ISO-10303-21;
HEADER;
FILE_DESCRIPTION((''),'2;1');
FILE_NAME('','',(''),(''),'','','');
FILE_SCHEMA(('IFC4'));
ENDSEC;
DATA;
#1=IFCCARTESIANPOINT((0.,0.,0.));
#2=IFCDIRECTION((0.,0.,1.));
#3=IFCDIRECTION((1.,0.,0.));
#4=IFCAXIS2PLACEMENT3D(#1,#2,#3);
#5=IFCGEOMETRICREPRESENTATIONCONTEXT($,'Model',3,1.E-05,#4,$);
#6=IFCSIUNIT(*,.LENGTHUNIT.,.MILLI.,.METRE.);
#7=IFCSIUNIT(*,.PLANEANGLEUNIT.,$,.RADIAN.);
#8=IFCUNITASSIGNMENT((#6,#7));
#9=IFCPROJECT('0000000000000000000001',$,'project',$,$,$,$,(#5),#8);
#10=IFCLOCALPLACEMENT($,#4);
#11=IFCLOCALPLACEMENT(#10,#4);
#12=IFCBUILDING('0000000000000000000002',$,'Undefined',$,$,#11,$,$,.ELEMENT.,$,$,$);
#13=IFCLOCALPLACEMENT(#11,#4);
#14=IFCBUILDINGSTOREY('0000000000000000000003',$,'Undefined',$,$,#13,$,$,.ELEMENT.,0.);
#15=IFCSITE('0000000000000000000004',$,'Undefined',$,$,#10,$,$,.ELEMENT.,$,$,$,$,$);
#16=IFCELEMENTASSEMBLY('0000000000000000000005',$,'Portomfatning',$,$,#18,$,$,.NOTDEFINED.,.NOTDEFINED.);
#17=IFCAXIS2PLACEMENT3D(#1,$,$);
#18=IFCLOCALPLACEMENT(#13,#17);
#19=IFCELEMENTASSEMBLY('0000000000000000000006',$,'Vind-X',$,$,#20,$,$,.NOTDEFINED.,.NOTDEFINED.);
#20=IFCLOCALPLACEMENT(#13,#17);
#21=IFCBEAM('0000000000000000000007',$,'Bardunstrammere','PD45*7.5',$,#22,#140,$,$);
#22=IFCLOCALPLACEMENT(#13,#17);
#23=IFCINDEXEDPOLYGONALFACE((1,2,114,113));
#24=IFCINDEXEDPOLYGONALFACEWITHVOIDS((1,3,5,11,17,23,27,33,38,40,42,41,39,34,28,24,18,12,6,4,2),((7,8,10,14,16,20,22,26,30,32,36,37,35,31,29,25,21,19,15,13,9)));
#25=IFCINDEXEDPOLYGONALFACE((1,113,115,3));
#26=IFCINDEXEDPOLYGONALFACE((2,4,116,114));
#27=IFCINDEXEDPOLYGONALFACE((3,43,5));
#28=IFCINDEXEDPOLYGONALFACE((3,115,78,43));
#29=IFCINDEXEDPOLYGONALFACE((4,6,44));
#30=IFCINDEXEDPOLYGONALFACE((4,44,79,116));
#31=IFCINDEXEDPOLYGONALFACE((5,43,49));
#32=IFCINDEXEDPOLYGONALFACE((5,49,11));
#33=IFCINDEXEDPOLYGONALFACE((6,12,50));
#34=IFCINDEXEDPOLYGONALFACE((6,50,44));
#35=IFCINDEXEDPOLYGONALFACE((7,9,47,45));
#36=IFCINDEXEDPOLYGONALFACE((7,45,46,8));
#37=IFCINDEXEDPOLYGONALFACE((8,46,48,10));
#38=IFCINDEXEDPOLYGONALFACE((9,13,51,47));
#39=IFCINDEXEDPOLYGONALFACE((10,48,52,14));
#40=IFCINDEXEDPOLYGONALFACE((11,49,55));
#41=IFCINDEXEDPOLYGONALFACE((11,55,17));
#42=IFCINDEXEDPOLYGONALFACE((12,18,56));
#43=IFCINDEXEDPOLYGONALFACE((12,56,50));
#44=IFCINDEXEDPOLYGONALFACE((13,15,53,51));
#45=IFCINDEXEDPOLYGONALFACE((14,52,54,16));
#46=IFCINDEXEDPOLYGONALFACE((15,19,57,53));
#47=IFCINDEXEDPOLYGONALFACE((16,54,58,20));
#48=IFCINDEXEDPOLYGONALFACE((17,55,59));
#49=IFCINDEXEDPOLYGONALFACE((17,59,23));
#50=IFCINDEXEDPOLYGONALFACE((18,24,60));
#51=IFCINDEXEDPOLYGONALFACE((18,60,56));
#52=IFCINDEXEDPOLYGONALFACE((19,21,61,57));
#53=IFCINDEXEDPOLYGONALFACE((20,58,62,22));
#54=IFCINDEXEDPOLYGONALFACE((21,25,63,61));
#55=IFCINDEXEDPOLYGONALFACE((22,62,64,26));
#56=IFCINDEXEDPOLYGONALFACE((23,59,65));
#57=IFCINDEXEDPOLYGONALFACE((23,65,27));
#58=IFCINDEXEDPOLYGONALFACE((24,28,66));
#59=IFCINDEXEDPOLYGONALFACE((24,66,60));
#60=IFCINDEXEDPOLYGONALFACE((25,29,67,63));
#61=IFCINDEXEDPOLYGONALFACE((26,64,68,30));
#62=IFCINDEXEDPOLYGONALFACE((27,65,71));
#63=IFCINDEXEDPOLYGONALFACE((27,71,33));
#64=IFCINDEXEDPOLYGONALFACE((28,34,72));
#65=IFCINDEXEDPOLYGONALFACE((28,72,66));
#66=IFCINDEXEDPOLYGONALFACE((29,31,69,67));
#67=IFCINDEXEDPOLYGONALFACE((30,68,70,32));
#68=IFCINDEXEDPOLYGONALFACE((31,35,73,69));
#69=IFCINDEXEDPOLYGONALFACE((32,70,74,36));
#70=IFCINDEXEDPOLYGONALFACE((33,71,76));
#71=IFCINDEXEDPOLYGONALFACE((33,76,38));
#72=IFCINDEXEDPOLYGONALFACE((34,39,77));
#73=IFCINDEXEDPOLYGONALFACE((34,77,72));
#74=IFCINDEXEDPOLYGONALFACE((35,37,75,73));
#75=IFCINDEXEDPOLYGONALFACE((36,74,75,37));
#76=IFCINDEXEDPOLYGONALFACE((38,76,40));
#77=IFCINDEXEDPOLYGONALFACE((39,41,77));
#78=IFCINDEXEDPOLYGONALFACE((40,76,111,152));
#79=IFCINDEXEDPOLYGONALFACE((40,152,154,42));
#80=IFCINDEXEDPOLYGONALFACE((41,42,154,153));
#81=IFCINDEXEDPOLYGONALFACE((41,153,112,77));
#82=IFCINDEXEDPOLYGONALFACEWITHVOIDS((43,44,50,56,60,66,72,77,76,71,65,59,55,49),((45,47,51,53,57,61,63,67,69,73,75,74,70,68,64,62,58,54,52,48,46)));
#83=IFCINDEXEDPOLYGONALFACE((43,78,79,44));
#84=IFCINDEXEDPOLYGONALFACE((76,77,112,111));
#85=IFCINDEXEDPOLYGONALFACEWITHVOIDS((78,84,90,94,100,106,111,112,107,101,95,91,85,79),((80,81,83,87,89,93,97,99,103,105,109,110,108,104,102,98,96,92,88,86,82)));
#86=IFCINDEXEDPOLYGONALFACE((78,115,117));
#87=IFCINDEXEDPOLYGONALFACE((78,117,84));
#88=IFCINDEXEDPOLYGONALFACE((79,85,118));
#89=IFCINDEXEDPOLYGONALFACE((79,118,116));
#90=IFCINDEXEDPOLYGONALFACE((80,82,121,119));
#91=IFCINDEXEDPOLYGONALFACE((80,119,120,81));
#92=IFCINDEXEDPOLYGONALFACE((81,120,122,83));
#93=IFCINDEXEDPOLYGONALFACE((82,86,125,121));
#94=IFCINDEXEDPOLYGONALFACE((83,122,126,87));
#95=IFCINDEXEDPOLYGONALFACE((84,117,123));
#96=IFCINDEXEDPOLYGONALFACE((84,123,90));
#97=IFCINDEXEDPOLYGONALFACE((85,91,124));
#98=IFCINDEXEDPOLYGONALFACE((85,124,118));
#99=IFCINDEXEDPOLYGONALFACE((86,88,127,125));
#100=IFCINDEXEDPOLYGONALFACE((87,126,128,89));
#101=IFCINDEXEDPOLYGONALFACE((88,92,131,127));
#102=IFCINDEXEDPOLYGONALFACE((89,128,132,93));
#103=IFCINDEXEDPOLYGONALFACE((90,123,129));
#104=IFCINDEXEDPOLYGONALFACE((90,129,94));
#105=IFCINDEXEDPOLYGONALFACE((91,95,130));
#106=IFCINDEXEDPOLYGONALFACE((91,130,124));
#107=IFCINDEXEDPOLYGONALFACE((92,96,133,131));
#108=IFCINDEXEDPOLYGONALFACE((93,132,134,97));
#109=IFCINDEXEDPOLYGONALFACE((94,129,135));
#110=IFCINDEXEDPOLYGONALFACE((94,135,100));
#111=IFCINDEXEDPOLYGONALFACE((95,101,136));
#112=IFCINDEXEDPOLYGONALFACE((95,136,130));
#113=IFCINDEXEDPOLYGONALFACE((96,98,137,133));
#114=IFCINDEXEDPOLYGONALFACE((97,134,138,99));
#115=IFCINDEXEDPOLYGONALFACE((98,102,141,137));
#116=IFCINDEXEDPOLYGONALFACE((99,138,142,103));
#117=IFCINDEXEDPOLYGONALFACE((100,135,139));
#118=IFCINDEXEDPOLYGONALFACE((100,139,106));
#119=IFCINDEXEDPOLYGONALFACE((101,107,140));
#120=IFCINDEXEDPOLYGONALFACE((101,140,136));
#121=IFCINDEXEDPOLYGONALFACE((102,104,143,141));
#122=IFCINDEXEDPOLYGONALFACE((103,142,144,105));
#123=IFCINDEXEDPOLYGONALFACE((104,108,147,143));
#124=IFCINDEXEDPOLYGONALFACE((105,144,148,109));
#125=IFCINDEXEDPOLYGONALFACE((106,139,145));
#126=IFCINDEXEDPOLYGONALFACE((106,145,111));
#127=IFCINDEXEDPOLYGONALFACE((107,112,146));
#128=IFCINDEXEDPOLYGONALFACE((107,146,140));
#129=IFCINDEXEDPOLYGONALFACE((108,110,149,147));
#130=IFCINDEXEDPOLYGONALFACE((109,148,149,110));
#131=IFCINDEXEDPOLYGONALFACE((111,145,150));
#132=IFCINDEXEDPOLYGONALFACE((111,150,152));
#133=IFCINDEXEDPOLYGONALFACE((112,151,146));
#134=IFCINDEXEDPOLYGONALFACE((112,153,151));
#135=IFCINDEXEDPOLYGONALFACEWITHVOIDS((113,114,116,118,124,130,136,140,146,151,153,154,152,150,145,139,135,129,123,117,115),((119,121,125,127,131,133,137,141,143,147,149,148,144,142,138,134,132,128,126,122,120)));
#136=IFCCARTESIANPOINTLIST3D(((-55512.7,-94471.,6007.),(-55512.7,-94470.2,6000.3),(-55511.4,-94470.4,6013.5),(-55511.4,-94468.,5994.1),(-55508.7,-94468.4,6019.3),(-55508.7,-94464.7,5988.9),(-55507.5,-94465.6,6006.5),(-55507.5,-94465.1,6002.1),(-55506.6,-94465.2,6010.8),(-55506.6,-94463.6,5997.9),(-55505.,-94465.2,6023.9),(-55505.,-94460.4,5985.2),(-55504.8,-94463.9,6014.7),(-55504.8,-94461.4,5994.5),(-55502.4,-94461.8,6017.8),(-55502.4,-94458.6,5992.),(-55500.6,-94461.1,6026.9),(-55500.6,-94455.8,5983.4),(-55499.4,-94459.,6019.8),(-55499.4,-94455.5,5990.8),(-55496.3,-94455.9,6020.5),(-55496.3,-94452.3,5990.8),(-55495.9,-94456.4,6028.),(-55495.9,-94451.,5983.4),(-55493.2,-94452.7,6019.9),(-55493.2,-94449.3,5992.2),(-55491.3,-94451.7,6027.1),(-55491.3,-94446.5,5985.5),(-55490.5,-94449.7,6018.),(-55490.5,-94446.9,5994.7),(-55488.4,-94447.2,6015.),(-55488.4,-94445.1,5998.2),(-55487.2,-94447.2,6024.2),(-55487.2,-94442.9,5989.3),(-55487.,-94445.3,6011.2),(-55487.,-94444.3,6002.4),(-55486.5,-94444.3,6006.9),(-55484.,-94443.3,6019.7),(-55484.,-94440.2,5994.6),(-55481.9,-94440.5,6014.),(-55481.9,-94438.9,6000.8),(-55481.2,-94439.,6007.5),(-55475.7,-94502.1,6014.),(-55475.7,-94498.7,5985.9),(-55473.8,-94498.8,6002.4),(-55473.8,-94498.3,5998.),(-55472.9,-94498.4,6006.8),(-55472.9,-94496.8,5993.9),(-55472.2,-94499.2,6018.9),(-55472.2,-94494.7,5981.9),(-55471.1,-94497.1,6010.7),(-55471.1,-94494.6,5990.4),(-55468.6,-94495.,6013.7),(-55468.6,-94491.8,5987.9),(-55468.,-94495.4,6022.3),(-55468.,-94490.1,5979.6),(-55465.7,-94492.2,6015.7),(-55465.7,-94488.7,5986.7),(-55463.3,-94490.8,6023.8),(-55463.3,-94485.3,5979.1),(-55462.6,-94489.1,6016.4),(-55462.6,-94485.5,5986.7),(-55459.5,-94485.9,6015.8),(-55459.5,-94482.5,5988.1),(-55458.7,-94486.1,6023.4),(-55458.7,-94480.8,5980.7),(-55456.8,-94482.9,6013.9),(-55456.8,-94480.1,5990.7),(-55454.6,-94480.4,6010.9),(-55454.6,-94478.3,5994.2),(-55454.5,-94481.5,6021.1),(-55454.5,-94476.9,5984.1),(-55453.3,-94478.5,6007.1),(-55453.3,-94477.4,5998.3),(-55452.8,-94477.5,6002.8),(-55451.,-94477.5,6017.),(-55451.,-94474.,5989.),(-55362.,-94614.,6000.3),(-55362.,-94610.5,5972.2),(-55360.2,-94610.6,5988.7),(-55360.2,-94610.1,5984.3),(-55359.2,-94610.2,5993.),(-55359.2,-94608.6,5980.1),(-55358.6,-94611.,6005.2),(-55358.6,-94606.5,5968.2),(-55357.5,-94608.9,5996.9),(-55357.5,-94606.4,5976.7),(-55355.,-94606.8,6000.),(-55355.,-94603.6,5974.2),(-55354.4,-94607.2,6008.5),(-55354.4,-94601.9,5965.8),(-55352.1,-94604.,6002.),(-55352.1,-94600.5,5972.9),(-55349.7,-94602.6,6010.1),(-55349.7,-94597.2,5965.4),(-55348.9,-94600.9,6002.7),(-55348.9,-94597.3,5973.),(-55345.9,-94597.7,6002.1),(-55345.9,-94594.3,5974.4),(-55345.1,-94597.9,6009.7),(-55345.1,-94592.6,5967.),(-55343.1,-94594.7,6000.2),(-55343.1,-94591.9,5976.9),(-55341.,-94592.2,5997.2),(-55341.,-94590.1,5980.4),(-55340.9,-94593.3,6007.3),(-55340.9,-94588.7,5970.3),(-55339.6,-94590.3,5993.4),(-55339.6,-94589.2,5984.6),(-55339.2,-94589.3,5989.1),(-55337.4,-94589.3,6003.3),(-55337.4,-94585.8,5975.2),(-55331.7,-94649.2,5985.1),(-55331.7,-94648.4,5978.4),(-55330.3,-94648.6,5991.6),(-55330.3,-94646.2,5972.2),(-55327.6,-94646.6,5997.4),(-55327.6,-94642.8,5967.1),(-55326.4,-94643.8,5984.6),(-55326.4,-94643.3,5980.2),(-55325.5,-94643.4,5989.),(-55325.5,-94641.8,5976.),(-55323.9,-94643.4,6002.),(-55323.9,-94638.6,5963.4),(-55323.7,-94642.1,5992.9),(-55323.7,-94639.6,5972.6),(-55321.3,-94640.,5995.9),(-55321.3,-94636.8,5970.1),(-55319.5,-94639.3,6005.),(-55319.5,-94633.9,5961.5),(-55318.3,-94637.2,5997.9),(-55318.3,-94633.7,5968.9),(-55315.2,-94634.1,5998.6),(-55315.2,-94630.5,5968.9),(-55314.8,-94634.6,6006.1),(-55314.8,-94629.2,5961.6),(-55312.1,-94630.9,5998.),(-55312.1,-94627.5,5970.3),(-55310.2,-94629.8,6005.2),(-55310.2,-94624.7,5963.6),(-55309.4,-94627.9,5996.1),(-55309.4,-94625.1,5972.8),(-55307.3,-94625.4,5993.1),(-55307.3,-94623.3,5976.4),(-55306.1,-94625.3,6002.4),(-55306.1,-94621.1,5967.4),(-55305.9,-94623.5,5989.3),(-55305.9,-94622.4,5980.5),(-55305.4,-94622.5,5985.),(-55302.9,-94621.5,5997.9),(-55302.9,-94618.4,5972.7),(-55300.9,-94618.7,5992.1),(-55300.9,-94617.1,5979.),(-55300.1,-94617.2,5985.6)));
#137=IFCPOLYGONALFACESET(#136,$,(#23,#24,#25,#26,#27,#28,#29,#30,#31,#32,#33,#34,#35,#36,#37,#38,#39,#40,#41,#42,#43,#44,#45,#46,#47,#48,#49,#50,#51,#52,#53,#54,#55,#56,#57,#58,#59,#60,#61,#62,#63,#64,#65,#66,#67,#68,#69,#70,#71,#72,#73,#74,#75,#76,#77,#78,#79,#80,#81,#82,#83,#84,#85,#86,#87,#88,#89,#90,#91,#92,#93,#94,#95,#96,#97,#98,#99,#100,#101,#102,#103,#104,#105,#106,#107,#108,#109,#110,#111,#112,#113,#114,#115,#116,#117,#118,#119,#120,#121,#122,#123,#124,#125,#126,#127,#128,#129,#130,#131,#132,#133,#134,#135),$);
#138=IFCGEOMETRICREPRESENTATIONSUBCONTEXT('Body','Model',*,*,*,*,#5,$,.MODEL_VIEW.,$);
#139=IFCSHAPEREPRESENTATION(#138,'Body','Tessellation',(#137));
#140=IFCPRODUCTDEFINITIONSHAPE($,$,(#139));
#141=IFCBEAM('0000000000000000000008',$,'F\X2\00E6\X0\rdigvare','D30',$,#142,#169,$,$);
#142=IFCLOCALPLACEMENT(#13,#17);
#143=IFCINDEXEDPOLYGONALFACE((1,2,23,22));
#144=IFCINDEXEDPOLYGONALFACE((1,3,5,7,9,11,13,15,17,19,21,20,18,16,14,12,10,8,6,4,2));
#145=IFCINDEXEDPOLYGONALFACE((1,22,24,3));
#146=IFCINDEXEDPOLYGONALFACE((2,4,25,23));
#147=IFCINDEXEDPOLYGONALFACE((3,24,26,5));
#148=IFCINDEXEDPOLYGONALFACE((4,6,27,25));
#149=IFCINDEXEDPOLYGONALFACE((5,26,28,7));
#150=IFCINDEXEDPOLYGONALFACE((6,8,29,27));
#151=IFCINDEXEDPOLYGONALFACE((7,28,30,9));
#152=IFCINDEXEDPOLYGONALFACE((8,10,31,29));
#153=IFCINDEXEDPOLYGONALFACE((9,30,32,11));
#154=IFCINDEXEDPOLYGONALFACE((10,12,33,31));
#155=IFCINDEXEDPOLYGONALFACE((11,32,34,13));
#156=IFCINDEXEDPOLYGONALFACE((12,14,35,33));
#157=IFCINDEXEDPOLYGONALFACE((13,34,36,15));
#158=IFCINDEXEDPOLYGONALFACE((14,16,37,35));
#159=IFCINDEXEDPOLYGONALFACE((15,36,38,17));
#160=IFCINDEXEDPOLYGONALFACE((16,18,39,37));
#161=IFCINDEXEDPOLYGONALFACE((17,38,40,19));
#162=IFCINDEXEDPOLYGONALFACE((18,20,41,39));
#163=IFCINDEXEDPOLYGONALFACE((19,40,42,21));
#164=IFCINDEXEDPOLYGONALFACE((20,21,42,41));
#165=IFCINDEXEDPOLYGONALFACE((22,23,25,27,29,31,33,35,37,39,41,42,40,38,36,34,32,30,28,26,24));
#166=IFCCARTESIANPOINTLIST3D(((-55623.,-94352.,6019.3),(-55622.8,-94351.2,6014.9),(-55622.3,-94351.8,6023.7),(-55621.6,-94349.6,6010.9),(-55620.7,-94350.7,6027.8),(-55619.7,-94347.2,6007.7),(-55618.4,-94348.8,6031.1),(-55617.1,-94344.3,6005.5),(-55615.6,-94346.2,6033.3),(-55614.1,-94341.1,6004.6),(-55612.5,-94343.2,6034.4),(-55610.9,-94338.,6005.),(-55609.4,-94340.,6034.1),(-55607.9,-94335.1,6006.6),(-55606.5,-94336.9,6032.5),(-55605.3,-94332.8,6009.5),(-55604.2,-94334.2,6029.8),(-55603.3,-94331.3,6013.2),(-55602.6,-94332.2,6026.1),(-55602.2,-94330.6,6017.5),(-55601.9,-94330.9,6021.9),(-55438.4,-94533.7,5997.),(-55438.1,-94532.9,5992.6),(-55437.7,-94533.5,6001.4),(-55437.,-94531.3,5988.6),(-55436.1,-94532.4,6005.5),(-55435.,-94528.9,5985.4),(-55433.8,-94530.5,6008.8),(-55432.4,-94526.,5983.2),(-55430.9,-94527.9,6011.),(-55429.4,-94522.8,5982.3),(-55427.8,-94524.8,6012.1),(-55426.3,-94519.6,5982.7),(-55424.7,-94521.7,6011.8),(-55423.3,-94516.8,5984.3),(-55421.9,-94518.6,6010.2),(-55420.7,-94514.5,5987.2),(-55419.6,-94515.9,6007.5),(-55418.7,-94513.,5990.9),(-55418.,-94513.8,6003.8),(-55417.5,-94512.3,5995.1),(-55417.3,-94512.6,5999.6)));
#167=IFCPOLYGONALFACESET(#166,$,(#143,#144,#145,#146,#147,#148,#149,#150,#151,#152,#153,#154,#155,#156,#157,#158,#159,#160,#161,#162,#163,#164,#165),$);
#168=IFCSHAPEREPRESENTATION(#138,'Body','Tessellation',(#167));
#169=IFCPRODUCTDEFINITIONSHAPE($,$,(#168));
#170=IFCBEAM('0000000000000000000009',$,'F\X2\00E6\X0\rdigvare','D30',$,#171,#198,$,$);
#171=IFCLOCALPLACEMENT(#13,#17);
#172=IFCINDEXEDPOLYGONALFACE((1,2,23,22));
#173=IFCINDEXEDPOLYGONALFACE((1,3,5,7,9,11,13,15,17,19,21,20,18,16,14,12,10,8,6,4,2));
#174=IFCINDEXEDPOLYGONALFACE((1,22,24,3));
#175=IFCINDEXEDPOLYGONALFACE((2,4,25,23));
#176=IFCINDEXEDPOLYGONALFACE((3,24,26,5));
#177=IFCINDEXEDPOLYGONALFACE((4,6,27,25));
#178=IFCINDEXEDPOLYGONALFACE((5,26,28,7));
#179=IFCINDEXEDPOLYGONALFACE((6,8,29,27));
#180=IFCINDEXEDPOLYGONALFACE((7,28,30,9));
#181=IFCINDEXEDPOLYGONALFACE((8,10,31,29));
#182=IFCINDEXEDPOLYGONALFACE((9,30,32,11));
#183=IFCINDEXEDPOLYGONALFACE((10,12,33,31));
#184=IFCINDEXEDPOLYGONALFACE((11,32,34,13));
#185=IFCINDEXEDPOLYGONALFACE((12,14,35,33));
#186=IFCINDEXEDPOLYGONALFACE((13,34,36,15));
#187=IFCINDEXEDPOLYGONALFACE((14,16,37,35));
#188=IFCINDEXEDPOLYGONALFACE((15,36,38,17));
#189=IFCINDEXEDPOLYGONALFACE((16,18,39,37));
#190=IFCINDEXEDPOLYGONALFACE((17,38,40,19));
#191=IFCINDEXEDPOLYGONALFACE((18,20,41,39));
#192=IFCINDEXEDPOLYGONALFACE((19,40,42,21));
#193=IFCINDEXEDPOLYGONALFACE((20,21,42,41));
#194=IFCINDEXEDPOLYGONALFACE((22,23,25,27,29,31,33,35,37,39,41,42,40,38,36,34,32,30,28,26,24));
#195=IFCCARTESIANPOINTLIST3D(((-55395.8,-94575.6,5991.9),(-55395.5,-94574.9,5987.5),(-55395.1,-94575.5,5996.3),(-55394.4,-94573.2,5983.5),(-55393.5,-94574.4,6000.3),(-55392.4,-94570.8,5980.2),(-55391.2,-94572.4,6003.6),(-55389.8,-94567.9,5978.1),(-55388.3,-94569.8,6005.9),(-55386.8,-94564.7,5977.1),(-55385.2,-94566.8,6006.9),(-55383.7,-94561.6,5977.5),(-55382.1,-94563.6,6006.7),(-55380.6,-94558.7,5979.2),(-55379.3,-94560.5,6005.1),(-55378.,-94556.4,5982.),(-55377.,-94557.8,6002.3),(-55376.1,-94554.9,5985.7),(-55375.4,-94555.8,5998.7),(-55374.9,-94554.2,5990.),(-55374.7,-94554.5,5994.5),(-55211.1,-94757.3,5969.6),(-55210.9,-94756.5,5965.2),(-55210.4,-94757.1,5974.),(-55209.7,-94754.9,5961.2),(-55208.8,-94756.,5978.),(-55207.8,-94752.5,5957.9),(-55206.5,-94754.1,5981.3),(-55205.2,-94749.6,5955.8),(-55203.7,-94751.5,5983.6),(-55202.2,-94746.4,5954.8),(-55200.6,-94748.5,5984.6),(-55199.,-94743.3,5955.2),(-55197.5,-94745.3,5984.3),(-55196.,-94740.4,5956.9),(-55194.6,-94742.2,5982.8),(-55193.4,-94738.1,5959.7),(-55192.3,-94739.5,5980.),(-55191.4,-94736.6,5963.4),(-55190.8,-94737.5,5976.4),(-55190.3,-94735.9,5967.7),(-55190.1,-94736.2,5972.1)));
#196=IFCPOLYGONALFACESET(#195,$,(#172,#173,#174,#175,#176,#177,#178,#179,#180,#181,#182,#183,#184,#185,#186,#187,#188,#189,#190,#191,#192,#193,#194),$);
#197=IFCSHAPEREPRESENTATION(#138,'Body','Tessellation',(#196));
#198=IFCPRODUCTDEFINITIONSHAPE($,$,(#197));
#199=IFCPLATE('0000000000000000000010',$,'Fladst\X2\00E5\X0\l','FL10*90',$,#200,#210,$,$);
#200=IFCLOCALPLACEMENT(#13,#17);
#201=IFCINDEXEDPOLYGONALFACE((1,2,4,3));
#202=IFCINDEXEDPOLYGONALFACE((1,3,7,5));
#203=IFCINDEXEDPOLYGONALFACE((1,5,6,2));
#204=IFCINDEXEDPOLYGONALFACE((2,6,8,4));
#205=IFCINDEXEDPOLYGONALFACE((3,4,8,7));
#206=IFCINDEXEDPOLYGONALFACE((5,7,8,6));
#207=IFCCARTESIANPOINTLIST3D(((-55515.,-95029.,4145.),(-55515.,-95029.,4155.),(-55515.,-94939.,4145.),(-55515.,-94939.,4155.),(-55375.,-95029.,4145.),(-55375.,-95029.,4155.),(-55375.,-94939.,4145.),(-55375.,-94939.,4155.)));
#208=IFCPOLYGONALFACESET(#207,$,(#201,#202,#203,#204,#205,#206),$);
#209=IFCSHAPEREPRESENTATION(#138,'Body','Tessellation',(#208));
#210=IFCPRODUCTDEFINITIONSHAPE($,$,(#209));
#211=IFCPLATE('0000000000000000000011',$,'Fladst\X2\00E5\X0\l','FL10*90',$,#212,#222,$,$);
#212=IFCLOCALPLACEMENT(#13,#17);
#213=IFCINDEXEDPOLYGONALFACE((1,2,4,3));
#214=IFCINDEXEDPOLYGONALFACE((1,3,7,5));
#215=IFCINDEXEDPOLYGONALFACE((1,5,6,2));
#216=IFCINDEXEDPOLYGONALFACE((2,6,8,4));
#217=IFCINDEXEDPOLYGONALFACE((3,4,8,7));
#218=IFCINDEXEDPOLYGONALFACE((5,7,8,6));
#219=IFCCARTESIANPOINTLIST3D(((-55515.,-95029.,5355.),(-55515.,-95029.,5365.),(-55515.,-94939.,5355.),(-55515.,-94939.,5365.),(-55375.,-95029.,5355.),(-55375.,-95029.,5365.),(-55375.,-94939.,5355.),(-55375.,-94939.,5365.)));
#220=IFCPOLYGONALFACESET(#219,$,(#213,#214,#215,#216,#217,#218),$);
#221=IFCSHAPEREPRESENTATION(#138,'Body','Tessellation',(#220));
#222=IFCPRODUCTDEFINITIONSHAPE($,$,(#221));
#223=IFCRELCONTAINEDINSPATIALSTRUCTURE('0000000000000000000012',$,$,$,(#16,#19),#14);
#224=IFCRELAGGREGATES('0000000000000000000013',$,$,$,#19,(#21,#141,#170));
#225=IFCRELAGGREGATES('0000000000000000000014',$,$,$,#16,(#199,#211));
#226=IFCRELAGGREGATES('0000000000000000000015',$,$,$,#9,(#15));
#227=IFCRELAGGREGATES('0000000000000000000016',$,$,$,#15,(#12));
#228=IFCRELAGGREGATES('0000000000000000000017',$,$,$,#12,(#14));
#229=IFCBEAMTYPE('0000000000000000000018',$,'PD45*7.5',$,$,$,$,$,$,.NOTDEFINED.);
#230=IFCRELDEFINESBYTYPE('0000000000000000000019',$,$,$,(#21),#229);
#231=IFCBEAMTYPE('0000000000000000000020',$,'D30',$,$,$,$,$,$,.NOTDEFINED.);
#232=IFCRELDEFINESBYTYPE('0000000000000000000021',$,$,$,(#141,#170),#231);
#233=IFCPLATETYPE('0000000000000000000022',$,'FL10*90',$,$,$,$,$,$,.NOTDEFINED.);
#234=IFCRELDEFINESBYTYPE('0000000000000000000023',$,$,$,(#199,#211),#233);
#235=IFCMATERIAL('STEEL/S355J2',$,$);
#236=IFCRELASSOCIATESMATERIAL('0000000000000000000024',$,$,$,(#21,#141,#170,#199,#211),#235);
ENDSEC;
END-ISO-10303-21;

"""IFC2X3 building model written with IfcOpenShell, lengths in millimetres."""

from ifc_helpers import new_model, si_unit, frame, origin_with_axes, origin_2d_with_axis, place, context, subcontext, project, spatial, polyline, rectangle, circle, hollow_circle, outline, extrude, boolean, material, type_object, element, aggregate, save


model = new_model("IFC2X3")

# Units and contexts
model_context = context("Model", 3, precision=1e-05, world=origin_with_axes())
body_context = subcontext(model_context, "Body", "Model", "MODEL_VIEW")
ifc_project = project(units=[si_unit("LENGTHUNIT", "METRE", prefix="MILLI"), si_unit("PLANEANGLEUNIT", "RADIAN")], contexts=[model_context])

# Site, building, storey
site_placement = place(None, origin_with_axes())
site = spatial("IfcSite", under=ifc_project, at=site_placement, Name="Undefined", CompositionType="ELEMENT")
building_placement = place(site_placement, origin_with_axes())
building = spatial("IfcBuilding", under=site, at=building_placement, Name="Undefined", CompositionType="ELEMENT")
storey_placement = place(building_placement, origin_with_axes())
storey = spatial("IfcBuildingStorey", under=building, at=storey_placement, Name="Undefined", CompositionType="ELEMENT", Elevation=0.0)

# Element assembly
assembly_1_placement = place(storey_placement, origin_with_axes())
assembly_1 = element("IfcElementAssembly", 1, at=assembly_1_placement, inside=storey, Name="Portomfatning", AssemblyPlace="NOTDEFINED", PredefinedType="NOTDEFINED")

# Element assembly, beams
assembly_2_placement = place(storey_placement, origin_with_axes())
assembly_2 = element("IfcElementAssembly", 2, at=assembly_2_placement, inside=storey, Name="Vind-X", AssemblyPlace="NOTDEFINED", PredefinedType="NOTDEFINED")
ifc_material_1 = material(Name="STEEL/S355J2")
beam_type_1 = type_object("IfcBeamType", Name="PD45*7.5", PredefinedType="NOTDEFINED")
beam_1_placement = place(assembly_2_placement, frame((-55316.0, -94633.1, 5983.7), z_axis=(0.0, -0.121869, 0.992546), x_axis=(-0.710169, 0.698783, 0.0858)))
beam_1 = element("IfcBeam", 3, at=beam_1_placement, type_object=beam_type_1, material=ifc_material_1, Name="Bardunstrammere", Description="PD45*7.5", context=body_context, shape_type="CSG", body=[
    boolean("DIFFERENCE", extrude(hollow_circle(Radius=22.5, WallThickness=7.5, at=origin_2d_with_axis()), frame((255.0, 0.0, 0.0), z_axis=(-1.0, 0.0, 0.0), x_axis=(0.0, -1.0, 0.0)), (0.0, 0.0, 1.0), 255.0), extrude(rectangle(XDim=35.0, YDim=90.0, at=origin_2d_with_axis()), frame((207.5, 0.0, 0.0), z_axis=(-1.0, 0.0, 0.0), x_axis=(0.0, -1.0, 0.0)), (0.0, 0.0, 1.0), 160.0)),
])
beam_type_2 = type_object("IfcBeamType", Name="D30", PredefinedType="NOTDEFINED")
beam_2_placement = place(assembly_2_placement, frame((-55427.8, -94523.0, 5997.2), z_axis=(-0.70403, -0.704877, -0.086548), x_axis=(-0.71017, 0.698782, 0.0858)))
beam_2 = element("IfcBeam", 4, at=beam_2_placement, type_object=beam_type_2, material=ifc_material_1, Name="Færdigvare", Description="D30", context=body_context, shape_type="SweptSolid", body=[
    extrude(circle(Radius=15.0, at=origin_2d_with_axis()), frame((260.0, 0.0, 0.0), z_axis=(-1.0, 0.0, 0.0), x_axis=(0.0, -1.0, 0.0)), (0.0, 0.0, 1.0), 260.0),
])
beam_3_placement = place(assembly_2_placement, frame((-55200.6, -94746.6, 5969.7), z_axis=(-0.704031, -0.704876, -0.086548), x_axis=(-0.710169, 0.698783, 0.0858)))
beam_3 = element("IfcBeam", 5, at=beam_3_placement, type_object=beam_type_2, material=ifc_material_1, Name="Færdigvare", Description="D30", context=body_context, shape_type="SweptSolid", body=[
    extrude(circle(Radius=15.0, at=origin_2d_with_axis()), frame((260.0, 0.0, 0.0), z_axis=(-1.0, 0.0, 0.0), x_axis=(0.0, -1.0, 0.0)), (0.0, 0.0, 1.0), 260.0),
])
aggregate(assembly_2, [beam_1, beam_2, beam_3])

# Plates
plate_type_1 = type_object("IfcPlateType", Name="FL10*90", PredefinedType="NOTDEFINED")
plate_1_placement = place(assembly_1_placement, frame((-55515.0, -94984.0, 4150.0), z_axis=(0.0, 0.0, 1.0), x_axis=(1.0, 0.0, 0.0)))
plate_1 = element("IfcPlate", 6, at=plate_1_placement, type_object=plate_type_1, material=ifc_material_1, Name="Fladstål", Description="FL10*90", context=body_context, shape_type="SweptSolid", body=[
    extrude(outline(polyline([(0.0, -45.0), (0.0, 45.0), (140.0, 45.0), (140.0, -45.0), (0.0, -45.0)])), frame((0.0, 0.0, -5.0), z_axis=(0.0, 0.0, 1.0), x_axis=(1.0, 0.0, 0.0)), (0.0, 0.0, 1.0), 10.0),
])
plate_2_placement = place(assembly_1_placement, frame((-55515.0, -94984.0, 5360.0), z_axis=(0.0, 0.0, -1.0), x_axis=(1.0, 0.0, 0.0)))
plate_2 = element("IfcPlate", 7, at=plate_2_placement, type_object=plate_type_1, material=ifc_material_1, Name="Fladstål", Description="FL10*90", context=body_context, shape_type="SweptSolid", body=[
    extrude(outline(polyline([(0.0, -45.0), (0.0, 45.0), (140.0, 45.0), (140.0, -45.0), (0.0, -45.0)])), frame((0.0, 0.0, -5.0), z_axis=(0.0, 0.0, 1.0), x_axis=(1.0, 0.0, 0.0)), (0.0, 0.0, 1.0), 10.0),
])

aggregate(assembly_1, [plate_1, plate_2])

save(model, "model.ifc")
